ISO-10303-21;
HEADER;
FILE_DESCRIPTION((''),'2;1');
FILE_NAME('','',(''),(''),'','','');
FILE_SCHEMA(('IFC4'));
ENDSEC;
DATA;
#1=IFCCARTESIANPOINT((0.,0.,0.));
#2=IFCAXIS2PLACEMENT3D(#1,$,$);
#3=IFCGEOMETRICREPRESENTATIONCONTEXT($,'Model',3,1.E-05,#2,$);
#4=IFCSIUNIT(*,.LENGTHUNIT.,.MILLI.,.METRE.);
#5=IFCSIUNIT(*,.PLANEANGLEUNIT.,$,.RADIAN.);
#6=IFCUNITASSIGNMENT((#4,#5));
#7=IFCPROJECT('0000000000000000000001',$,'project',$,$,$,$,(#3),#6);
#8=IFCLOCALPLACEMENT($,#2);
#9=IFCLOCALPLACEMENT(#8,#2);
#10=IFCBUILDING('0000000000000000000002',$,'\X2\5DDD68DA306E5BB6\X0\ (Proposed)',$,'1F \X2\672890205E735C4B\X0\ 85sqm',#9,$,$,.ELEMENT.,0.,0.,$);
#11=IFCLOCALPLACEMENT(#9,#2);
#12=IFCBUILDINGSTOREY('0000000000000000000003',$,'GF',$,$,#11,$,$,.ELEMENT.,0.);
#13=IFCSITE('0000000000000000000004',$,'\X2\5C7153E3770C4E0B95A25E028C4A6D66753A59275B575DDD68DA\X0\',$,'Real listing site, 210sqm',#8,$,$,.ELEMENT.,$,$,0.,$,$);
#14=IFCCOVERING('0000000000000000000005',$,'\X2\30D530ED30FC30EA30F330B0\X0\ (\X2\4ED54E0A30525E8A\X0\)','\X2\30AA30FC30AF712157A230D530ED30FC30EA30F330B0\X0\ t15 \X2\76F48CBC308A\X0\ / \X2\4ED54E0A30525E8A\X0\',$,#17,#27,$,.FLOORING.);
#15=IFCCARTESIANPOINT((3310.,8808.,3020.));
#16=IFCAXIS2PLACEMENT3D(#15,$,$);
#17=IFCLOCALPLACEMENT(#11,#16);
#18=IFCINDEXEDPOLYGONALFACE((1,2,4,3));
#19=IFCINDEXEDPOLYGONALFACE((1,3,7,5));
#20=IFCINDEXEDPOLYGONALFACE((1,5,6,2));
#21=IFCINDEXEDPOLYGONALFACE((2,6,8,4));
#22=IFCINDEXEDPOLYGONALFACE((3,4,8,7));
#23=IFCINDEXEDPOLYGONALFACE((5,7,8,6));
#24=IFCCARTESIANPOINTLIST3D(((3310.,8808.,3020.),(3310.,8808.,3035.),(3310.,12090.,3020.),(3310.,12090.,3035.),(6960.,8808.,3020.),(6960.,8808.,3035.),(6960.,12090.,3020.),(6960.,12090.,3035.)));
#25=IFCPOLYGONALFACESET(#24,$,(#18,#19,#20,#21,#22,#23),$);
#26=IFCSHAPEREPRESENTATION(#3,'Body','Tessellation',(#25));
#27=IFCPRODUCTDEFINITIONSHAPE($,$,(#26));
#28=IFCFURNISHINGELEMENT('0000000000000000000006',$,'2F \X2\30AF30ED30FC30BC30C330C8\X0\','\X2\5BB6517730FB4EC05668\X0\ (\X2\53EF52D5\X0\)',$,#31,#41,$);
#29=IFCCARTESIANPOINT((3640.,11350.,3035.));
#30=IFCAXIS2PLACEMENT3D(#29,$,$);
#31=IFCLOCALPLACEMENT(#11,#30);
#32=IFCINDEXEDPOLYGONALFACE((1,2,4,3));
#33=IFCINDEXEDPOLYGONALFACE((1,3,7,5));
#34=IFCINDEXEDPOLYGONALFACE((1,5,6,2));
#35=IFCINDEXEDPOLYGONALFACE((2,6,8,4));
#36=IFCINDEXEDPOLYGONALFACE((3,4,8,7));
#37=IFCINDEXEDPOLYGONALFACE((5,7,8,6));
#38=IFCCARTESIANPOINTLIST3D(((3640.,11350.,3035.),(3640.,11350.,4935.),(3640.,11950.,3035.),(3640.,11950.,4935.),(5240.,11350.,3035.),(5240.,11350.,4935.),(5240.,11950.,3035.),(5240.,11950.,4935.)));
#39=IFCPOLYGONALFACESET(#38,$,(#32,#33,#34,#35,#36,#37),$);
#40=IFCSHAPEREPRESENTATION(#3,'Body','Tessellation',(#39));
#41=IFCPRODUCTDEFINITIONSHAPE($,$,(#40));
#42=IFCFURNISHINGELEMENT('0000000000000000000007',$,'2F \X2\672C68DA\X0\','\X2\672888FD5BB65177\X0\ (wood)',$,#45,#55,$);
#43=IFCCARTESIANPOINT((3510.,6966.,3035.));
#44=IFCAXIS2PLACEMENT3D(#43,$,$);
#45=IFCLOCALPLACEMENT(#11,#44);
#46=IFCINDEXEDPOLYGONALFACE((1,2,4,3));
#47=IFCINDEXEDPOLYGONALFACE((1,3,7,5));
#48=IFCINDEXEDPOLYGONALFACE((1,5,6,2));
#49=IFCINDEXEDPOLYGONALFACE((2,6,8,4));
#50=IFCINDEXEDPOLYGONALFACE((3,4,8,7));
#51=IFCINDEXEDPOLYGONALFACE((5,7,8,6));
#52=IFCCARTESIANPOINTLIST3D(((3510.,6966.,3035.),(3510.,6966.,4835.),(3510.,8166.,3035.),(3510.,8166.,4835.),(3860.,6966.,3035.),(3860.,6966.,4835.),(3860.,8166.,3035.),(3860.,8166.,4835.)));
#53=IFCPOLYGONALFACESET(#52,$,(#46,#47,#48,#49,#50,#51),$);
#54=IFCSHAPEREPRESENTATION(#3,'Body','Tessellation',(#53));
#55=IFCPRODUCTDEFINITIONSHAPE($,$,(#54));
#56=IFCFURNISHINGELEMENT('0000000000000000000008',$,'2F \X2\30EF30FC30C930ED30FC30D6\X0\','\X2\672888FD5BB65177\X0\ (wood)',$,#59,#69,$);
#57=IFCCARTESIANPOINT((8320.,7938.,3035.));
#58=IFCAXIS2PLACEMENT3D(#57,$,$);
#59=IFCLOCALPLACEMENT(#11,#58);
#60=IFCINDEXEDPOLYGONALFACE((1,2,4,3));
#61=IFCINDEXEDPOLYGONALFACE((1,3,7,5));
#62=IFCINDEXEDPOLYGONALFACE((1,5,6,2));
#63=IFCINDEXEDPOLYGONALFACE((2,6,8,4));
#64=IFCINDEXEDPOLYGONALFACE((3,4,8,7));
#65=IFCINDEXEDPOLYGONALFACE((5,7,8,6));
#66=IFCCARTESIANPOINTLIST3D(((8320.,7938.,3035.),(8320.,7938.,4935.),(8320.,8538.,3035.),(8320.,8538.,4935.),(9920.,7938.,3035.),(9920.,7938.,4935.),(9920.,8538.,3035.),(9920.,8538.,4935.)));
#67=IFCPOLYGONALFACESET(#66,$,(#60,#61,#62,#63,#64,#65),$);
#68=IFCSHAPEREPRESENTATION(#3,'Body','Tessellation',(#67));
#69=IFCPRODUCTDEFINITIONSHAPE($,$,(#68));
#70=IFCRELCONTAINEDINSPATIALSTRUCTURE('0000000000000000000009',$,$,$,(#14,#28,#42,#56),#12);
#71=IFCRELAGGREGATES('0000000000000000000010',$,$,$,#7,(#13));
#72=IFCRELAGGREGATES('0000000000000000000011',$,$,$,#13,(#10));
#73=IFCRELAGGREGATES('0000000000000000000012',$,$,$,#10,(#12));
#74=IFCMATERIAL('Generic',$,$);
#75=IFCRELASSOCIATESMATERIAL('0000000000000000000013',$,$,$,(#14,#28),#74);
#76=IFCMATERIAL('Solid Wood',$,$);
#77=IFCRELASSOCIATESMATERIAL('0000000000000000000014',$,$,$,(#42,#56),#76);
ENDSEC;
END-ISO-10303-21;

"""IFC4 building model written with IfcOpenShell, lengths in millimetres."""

from ifc_helpers import new_model, si_unit, frame, frame_2d, origin, place, context, project, spatial, rectangle, extrude, material, element, save


model = new_model("IFC4")

# Units and contexts
model_context = context("Model", 3, precision=1e-05, world=origin())
ifc_project = project(units=[si_unit("LENGTHUNIT", "METRE", prefix="MILLI"), si_unit("PLANEANGLEUNIT", "RADIAN")], contexts=[model_context])

# Site, building, storey
site_placement = place(None, origin())
site = spatial("IfcSite", under=ifc_project, at=site_placement, Name="山口県下関市豊浦町大字川棚", ObjectType="Real listing site, 210sqm", CompositionType="ELEMENT", RefElevation=0.0)
building_placement = place(site_placement, origin())
building = spatial("IfcBuilding", under=site, at=building_placement, Name="川棚の家 (Proposed)", ObjectType="1F 木造平屋 85sqm", CompositionType="ELEMENT", ElevationOfRefHeight=0.0, ElevationOfTerrain=0.0)
storey_placement = place(building_placement, origin())
storey = spatial("IfcBuildingStorey", under=building, at=storey_placement, Name="GF", CompositionType="ELEMENT", Elevation=0.0)

# Shared definitions
ifc_material_1 = material(Name="Solid Wood")

# Shared definitions
ifc_material_2 = material(Name="Generic")

# Covering
covering_placement = place(storey_placement, frame((3310.0, 8808.0, 3020.0)))
element("IfcCovering", 1, at=covering_placement, inside=storey, material=ifc_material_2, Name="フローリング (仕上げ床)", Description="オーク無垢フローリング t15 直貼り / 仕上げ床", PredefinedType="FLOORING", context=model_context, shape_type="SweptSolid", body=[
    extrude(rectangle(XDim=3650.0, YDim=3282.0, at=frame_2d((1825.0, 1641.0))), frame((3310.0, 8808.0, 3020.0)), (0.0, 0.0, 1.0), 15.0),
])

# Furnishing elements
furnishing_1_placement = place(storey_placement, frame((3640.0, 11350.0, 3035.0)))
element("IfcFurnishingElement", 2, at=furnishing_1_placement, inside=storey, material=ifc_material_2, Name="2F クローゼット", Description="家具・什器 (可動)", context=model_context, shape_type="SweptSolid", body=[
    extrude(rectangle(XDim=1600.0, YDim=600.0, at=frame_2d((800.0, 300.0))), frame((3640.0, 11350.0, 3035.0)), (0.0, 0.0, 1.0), 1900.0),
])
furnishing_2_placement = place(storey_placement, frame((3510.0, 6966.0, 3035.0)))
element("IfcFurnishingElement", 3, at=furnishing_2_placement, inside=storey, material=ifc_material_1, Name="2F 本棚", Description="木製家具 (wood)", context=model_context, shape_type="SweptSolid", body=[
    extrude(rectangle(XDim=350.0, YDim=1200.0, at=frame_2d((175.0, 600.0))), frame((3510.0, 6966.0, 3035.0)), (0.0, 0.0, 1.0), 1800.0),
])
furnishing_3_placement = place(storey_placement, frame((8320.0, 7938.0, 3035.0)))
element("IfcFurnishingElement", 4, at=furnishing_3_placement, inside=storey, material=ifc_material_1, Name="2F ワードローブ", Description="木製家具 (wood)", context=model_context, shape_type="SweptSolid", body=[
    extrude(rectangle(XDim=1600.0, YDim=600.0, at=frame_2d((800.0, 300.0))), frame((8320.0, 7938.0, 3035.0)), (0.0, 0.0, 1.0), 1900.0),
])

save(model, "model.ifc")
